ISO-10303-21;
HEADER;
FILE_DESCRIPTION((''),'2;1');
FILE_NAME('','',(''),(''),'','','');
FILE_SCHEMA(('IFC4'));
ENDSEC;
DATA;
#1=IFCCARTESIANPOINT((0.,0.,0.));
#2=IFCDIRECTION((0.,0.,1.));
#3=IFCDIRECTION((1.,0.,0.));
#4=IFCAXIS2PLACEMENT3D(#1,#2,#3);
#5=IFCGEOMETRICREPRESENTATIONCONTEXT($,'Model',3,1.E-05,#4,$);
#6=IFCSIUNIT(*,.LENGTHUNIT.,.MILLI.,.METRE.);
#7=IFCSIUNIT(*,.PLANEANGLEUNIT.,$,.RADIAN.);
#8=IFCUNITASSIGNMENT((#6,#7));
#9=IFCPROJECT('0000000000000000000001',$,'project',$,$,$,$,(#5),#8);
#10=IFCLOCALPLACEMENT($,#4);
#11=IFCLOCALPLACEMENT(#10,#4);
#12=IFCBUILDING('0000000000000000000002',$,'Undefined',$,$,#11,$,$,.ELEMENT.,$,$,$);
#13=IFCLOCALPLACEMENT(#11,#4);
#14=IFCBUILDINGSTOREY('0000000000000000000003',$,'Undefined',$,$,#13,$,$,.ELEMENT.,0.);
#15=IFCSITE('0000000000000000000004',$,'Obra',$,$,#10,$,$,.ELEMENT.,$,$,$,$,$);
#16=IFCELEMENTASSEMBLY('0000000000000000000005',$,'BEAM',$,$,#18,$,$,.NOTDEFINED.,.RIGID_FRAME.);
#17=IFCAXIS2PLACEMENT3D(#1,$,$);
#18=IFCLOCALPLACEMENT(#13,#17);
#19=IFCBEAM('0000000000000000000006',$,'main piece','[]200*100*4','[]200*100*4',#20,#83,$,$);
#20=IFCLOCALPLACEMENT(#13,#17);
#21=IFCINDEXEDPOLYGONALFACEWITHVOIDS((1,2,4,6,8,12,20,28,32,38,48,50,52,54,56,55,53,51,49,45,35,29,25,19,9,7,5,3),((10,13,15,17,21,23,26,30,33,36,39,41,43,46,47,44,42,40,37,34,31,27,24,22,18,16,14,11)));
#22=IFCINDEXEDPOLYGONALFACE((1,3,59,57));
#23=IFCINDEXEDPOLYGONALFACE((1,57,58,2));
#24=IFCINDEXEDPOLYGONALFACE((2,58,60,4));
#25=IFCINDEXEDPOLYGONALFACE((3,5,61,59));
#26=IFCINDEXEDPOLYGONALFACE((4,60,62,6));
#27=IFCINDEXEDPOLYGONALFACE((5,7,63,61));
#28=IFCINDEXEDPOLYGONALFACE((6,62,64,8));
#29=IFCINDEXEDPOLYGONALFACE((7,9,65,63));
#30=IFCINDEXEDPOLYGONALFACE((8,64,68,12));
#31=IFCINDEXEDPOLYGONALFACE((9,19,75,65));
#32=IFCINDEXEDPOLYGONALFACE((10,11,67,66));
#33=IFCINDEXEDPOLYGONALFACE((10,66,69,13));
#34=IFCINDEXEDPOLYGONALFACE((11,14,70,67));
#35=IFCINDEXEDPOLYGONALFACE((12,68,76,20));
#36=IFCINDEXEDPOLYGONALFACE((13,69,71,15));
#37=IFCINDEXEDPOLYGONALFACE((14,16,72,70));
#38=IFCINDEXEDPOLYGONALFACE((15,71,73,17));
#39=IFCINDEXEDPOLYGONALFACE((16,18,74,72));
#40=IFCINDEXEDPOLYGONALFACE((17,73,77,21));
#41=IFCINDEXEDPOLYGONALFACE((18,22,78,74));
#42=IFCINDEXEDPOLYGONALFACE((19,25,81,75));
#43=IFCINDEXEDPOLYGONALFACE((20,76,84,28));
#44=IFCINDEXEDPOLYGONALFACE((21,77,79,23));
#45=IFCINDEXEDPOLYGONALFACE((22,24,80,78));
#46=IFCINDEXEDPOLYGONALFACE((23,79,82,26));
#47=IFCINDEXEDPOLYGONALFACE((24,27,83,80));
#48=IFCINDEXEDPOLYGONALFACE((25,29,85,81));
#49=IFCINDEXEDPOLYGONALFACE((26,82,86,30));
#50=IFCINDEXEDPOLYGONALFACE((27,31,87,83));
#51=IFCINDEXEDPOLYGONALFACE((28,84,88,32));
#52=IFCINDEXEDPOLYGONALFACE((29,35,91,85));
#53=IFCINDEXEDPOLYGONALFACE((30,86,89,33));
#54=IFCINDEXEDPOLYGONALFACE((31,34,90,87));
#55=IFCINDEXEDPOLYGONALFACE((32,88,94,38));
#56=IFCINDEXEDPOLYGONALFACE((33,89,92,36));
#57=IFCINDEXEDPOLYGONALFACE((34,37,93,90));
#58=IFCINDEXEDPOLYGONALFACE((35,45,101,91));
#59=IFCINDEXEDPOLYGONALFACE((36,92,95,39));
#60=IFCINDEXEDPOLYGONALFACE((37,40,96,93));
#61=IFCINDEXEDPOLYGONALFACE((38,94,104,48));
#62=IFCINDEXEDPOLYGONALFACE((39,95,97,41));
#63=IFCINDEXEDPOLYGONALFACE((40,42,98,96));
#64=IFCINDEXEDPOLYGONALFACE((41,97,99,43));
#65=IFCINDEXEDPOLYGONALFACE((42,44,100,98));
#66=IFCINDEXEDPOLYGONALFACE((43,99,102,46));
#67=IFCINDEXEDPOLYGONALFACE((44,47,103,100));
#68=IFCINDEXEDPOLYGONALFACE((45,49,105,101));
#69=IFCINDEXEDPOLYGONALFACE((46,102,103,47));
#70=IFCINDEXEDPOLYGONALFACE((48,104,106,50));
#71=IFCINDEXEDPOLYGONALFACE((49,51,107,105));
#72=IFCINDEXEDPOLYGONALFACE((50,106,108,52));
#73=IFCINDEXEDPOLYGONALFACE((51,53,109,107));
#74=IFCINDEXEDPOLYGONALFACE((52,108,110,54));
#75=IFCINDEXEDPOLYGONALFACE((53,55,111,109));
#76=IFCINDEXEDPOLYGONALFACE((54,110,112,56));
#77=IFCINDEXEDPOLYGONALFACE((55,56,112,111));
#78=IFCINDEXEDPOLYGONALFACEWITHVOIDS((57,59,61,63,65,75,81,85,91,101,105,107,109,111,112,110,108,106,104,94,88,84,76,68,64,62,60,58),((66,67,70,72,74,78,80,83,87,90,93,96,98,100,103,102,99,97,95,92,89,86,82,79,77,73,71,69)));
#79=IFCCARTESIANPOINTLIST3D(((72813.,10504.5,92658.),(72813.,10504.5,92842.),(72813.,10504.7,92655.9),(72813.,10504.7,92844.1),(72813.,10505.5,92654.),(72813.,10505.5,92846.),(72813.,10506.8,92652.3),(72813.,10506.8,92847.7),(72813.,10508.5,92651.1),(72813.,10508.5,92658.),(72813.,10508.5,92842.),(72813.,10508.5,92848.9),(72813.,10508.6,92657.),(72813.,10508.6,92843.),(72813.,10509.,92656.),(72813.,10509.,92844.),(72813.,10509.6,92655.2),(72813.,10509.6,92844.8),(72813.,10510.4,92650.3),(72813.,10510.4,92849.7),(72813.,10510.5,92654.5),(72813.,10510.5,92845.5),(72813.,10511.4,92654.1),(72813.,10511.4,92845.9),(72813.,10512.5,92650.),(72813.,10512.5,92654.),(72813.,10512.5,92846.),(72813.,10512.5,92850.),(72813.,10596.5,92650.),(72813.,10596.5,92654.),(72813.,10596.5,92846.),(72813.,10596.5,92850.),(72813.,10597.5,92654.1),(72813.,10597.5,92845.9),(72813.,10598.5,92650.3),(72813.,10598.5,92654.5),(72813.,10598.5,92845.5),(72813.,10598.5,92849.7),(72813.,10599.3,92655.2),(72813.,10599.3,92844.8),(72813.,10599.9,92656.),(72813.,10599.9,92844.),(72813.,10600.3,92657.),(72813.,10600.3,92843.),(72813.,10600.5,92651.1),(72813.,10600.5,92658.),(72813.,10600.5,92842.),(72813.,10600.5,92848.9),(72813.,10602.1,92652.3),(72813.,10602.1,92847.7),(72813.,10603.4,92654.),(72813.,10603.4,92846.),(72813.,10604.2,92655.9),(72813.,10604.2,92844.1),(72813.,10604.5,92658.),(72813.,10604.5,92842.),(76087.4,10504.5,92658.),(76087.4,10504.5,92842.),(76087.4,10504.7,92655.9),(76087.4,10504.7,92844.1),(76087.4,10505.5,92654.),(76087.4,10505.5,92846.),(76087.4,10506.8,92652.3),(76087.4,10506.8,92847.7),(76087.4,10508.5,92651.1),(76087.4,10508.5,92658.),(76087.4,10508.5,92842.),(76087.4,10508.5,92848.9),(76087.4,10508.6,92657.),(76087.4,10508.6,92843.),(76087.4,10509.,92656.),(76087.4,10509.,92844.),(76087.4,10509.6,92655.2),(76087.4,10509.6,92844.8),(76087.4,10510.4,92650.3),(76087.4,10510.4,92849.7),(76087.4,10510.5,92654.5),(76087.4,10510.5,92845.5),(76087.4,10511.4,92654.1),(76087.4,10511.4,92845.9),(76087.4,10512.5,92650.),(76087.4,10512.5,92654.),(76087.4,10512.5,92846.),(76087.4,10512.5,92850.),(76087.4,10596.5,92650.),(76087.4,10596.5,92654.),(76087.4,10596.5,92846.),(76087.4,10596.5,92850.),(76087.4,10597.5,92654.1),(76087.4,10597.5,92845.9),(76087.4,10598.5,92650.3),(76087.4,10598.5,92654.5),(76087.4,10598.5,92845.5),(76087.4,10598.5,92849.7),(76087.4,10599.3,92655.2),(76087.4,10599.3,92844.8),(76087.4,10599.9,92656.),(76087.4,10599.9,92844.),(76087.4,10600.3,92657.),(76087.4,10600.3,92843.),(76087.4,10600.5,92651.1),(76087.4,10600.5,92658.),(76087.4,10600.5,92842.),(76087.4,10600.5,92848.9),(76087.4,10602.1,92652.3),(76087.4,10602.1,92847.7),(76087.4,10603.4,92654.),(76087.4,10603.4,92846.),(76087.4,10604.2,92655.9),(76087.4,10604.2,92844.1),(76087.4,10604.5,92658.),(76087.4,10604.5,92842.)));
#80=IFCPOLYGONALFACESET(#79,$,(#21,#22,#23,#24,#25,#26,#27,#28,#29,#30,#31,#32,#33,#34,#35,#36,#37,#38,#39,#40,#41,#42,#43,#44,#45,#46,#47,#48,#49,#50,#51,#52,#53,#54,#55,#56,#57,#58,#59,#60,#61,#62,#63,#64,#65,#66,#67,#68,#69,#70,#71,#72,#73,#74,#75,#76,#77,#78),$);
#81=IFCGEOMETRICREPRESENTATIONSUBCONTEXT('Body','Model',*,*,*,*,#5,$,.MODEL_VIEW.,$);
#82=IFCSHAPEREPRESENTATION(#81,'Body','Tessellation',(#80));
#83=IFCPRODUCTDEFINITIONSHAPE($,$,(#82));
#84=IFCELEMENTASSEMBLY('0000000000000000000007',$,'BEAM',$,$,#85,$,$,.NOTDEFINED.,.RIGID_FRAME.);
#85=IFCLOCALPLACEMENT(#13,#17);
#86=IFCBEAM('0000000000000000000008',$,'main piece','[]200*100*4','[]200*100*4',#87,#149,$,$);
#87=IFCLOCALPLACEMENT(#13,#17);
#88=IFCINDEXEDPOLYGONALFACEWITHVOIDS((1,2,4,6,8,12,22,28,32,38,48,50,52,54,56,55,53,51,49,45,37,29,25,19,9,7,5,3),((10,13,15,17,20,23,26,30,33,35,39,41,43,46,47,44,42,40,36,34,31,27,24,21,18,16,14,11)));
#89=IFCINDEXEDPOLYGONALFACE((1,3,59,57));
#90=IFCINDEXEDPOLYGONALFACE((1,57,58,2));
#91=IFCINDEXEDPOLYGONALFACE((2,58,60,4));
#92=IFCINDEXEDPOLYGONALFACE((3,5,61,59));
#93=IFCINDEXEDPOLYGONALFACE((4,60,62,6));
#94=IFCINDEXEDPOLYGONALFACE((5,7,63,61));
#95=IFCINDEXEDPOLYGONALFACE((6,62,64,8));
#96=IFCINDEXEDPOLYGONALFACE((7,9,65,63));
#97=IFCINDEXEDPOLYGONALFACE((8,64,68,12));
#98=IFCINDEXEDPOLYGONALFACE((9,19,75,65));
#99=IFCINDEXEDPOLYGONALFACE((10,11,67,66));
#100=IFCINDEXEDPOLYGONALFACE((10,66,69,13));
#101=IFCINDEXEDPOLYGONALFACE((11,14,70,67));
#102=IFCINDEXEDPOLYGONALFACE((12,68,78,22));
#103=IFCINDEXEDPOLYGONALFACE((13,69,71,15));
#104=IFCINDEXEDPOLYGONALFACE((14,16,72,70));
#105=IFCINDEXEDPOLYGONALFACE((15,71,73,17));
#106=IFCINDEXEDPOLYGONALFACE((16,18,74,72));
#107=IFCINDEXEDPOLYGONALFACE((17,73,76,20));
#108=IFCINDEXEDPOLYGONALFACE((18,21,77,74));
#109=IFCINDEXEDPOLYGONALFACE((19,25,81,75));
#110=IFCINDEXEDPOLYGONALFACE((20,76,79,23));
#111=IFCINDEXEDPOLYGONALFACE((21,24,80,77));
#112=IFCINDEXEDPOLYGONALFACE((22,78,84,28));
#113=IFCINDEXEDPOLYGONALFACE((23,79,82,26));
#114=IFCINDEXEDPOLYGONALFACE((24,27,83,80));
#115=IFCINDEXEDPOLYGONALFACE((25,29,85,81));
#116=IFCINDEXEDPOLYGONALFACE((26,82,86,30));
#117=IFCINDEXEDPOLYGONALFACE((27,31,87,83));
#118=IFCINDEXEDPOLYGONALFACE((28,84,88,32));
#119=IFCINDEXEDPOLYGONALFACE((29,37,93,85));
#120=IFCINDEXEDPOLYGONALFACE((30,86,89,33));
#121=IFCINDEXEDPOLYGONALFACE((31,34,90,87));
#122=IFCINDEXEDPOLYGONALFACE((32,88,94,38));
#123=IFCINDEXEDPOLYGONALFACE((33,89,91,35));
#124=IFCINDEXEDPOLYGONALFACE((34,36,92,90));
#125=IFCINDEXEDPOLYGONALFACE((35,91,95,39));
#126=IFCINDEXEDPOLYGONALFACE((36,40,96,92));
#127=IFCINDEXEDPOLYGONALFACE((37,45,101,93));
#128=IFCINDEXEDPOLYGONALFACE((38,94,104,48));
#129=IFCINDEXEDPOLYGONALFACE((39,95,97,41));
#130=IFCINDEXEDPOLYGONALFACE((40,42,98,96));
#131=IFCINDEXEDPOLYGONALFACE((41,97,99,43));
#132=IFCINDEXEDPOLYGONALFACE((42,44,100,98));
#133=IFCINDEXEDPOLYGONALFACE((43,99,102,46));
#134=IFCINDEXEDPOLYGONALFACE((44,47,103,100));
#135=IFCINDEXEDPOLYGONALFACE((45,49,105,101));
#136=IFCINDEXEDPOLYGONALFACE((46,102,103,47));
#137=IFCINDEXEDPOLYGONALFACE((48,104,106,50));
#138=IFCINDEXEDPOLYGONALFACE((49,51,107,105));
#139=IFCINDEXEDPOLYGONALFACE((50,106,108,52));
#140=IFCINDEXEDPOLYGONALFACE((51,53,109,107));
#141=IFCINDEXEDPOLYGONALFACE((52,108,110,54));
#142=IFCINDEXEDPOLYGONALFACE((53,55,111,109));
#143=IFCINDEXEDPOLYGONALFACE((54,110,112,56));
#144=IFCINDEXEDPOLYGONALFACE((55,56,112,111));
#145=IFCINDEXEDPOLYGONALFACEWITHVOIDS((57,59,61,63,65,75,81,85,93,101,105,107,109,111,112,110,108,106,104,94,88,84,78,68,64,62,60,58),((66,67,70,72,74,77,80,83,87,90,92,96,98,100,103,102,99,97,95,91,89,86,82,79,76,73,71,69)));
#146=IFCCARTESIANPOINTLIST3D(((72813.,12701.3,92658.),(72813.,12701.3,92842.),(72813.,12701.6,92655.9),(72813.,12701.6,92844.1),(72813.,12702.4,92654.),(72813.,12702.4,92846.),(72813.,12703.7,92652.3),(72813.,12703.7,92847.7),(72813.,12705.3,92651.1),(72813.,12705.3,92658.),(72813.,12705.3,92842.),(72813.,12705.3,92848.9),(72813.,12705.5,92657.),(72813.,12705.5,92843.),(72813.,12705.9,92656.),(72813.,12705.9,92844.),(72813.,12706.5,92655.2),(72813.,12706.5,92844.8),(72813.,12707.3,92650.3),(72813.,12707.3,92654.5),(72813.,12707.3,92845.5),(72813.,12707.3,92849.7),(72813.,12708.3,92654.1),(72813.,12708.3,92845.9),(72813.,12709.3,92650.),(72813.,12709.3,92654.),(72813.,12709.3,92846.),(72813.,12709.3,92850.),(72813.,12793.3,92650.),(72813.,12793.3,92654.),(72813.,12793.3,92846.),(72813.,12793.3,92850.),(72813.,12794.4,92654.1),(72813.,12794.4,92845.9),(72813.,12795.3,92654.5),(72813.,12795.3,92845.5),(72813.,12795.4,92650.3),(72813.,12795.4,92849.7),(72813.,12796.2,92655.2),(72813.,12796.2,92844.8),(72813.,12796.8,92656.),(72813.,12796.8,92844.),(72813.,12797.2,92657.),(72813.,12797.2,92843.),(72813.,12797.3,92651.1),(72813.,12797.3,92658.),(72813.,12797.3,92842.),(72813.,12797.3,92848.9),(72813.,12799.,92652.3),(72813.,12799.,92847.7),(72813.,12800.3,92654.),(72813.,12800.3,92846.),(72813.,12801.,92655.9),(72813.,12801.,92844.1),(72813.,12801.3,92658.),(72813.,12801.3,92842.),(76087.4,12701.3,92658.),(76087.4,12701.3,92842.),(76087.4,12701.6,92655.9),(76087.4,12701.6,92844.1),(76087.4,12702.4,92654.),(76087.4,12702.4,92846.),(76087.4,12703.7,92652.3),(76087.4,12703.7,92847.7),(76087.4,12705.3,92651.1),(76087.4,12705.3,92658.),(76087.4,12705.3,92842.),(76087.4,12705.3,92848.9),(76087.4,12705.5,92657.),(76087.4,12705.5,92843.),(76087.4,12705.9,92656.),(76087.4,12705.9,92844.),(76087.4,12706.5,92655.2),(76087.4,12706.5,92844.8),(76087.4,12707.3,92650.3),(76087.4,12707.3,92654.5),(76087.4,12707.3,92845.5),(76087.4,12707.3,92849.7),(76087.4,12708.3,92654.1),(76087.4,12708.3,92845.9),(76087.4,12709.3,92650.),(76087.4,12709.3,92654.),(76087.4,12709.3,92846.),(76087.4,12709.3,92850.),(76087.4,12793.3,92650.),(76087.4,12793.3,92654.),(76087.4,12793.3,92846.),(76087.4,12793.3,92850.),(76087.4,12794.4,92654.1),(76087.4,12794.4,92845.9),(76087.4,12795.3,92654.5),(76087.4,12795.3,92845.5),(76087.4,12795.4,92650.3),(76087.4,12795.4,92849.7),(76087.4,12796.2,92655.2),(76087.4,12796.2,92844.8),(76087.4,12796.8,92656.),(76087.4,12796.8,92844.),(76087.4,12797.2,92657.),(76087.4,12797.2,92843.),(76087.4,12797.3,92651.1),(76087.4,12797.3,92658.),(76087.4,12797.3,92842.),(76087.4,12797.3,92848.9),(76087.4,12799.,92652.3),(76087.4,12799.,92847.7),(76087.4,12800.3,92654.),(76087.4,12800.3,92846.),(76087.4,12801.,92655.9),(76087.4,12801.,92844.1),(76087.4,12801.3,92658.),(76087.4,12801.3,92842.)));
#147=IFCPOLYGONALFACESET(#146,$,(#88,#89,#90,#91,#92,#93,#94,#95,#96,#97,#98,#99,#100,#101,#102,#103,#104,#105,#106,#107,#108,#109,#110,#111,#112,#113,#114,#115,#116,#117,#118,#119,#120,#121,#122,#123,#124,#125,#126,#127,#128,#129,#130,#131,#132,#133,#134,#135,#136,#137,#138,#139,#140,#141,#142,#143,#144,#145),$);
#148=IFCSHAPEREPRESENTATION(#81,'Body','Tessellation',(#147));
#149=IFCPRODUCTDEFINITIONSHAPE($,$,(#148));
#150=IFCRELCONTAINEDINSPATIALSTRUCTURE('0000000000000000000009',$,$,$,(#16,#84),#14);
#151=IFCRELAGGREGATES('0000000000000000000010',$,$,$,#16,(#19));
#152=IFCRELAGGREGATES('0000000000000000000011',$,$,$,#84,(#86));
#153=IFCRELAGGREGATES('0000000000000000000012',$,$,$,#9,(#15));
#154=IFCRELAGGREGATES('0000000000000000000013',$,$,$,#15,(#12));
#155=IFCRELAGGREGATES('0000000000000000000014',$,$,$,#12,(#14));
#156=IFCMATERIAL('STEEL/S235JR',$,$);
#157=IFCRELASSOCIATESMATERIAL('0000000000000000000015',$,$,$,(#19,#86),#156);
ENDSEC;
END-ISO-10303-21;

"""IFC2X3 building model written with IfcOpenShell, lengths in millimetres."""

from ifc_helpers import new_model, si_unit, frame, origin_with_axes, origin_2d_with_axis, place, context, subcontext, project, spatial, hollow_rectangle, extrude, material, element, aggregate, save


model = new_model("IFC2X3")

# Units and contexts
model_context = context("Model", 3, precision=1e-05, world=origin_with_axes())
body_context = subcontext(model_context, "Body", "Model", "MODEL_VIEW")
ifc_project = project(units=[si_unit("LENGTHUNIT", "METRE", prefix="MILLI"), si_unit("PLANEANGLEUNIT", "RADIAN")], contexts=[model_context])

# Site, building, storey
site_placement = place(None, origin_with_axes())
site = spatial("IfcSite", under=ifc_project, at=site_placement, Name="Obra", CompositionType="ELEMENT")
building_placement = place(site_placement, origin_with_axes())
building = spatial("IfcBuilding", under=site, at=building_placement, Name="Undefined", CompositionType="ELEMENT")
storey_placement = place(building_placement, origin_with_axes())
storey = spatial("IfcBuildingStorey", under=building, at=storey_placement, Name="Undefined", CompositionType="ELEMENT", Elevation=0.0)

# Element assemblies, beams
assembly_1_placement = place(storey_placement, origin_with_axes())
assembly_1 = element("IfcElementAssembly", 1, at=assembly_1_placement, inside=storey, Name="BEAM", AssemblyPlace="NOTDEFINED", PredefinedType="RIGID_FRAME")
ifc_material = material(Name="STEEL/S235JR")
beam_1_placement = place(assembly_1_placement, frame((72813.0, 10554.5, 92750.0), z_axis=(0.0, 0.0, 1.0), x_axis=(1.0, 0.0, 0.0)))
beam_1 = element("IfcBeam", 2, at=beam_1_placement, material=ifc_material, Name="main piece", Description="[]200*100*4", ObjectType="[]200*100*4", context=body_context, shape_type="SweptSolid", body=[
    extrude(hollow_rectangle(XDim=100.0, YDim=200.0, WallThickness=4.0, InnerFilletRadius=4.0, OuterFilletRadius=8.0, at=origin_2d_with_axis()), frame((3274.4, 0.0, 0.0), z_axis=(-1.0, 0.0, 0.0), x_axis=(0.0, -1.0, 0.0)), (0.0, 0.0, 1.0), 3274.4),
])
aggregate(assembly_1, [beam_1])
assembly_2_placement = place(storey_placement, origin_with_axes())
assembly_2 = element("IfcElementAssembly", 3, at=assembly_2_placement, inside=storey, Name="BEAM", AssemblyPlace="NOTDEFINED", PredefinedType="RIGID_FRAME")
beam_2_placement = place(assembly_2_placement, frame((72813.0, 12751.3, 92750.0), z_axis=(0.0, 0.0, 1.0), x_axis=(1.0, 0.0, 0.0)))
beam_2 = element("IfcBeam", 4, at=beam_2_placement, material=ifc_material, Name="main piece", Description="[]200*100*4", ObjectType="[]200*100*4", context=body_context, shape_type="SweptSolid", body=[
    extrude(hollow_rectangle(XDim=100.0, YDim=200.0, WallThickness=4.0, InnerFilletRadius=4.0, OuterFilletRadius=8.0, at=origin_2d_with_axis()), frame((3274.4, 0.0, 0.0), z_axis=(-1.0, 0.0, 0.0), x_axis=(0.0, -1.0, 0.0)), (0.0, 0.0, 1.0), 3274.4),
])
aggregate(assembly_2, [beam_2])

save(model, "model.ifc")
